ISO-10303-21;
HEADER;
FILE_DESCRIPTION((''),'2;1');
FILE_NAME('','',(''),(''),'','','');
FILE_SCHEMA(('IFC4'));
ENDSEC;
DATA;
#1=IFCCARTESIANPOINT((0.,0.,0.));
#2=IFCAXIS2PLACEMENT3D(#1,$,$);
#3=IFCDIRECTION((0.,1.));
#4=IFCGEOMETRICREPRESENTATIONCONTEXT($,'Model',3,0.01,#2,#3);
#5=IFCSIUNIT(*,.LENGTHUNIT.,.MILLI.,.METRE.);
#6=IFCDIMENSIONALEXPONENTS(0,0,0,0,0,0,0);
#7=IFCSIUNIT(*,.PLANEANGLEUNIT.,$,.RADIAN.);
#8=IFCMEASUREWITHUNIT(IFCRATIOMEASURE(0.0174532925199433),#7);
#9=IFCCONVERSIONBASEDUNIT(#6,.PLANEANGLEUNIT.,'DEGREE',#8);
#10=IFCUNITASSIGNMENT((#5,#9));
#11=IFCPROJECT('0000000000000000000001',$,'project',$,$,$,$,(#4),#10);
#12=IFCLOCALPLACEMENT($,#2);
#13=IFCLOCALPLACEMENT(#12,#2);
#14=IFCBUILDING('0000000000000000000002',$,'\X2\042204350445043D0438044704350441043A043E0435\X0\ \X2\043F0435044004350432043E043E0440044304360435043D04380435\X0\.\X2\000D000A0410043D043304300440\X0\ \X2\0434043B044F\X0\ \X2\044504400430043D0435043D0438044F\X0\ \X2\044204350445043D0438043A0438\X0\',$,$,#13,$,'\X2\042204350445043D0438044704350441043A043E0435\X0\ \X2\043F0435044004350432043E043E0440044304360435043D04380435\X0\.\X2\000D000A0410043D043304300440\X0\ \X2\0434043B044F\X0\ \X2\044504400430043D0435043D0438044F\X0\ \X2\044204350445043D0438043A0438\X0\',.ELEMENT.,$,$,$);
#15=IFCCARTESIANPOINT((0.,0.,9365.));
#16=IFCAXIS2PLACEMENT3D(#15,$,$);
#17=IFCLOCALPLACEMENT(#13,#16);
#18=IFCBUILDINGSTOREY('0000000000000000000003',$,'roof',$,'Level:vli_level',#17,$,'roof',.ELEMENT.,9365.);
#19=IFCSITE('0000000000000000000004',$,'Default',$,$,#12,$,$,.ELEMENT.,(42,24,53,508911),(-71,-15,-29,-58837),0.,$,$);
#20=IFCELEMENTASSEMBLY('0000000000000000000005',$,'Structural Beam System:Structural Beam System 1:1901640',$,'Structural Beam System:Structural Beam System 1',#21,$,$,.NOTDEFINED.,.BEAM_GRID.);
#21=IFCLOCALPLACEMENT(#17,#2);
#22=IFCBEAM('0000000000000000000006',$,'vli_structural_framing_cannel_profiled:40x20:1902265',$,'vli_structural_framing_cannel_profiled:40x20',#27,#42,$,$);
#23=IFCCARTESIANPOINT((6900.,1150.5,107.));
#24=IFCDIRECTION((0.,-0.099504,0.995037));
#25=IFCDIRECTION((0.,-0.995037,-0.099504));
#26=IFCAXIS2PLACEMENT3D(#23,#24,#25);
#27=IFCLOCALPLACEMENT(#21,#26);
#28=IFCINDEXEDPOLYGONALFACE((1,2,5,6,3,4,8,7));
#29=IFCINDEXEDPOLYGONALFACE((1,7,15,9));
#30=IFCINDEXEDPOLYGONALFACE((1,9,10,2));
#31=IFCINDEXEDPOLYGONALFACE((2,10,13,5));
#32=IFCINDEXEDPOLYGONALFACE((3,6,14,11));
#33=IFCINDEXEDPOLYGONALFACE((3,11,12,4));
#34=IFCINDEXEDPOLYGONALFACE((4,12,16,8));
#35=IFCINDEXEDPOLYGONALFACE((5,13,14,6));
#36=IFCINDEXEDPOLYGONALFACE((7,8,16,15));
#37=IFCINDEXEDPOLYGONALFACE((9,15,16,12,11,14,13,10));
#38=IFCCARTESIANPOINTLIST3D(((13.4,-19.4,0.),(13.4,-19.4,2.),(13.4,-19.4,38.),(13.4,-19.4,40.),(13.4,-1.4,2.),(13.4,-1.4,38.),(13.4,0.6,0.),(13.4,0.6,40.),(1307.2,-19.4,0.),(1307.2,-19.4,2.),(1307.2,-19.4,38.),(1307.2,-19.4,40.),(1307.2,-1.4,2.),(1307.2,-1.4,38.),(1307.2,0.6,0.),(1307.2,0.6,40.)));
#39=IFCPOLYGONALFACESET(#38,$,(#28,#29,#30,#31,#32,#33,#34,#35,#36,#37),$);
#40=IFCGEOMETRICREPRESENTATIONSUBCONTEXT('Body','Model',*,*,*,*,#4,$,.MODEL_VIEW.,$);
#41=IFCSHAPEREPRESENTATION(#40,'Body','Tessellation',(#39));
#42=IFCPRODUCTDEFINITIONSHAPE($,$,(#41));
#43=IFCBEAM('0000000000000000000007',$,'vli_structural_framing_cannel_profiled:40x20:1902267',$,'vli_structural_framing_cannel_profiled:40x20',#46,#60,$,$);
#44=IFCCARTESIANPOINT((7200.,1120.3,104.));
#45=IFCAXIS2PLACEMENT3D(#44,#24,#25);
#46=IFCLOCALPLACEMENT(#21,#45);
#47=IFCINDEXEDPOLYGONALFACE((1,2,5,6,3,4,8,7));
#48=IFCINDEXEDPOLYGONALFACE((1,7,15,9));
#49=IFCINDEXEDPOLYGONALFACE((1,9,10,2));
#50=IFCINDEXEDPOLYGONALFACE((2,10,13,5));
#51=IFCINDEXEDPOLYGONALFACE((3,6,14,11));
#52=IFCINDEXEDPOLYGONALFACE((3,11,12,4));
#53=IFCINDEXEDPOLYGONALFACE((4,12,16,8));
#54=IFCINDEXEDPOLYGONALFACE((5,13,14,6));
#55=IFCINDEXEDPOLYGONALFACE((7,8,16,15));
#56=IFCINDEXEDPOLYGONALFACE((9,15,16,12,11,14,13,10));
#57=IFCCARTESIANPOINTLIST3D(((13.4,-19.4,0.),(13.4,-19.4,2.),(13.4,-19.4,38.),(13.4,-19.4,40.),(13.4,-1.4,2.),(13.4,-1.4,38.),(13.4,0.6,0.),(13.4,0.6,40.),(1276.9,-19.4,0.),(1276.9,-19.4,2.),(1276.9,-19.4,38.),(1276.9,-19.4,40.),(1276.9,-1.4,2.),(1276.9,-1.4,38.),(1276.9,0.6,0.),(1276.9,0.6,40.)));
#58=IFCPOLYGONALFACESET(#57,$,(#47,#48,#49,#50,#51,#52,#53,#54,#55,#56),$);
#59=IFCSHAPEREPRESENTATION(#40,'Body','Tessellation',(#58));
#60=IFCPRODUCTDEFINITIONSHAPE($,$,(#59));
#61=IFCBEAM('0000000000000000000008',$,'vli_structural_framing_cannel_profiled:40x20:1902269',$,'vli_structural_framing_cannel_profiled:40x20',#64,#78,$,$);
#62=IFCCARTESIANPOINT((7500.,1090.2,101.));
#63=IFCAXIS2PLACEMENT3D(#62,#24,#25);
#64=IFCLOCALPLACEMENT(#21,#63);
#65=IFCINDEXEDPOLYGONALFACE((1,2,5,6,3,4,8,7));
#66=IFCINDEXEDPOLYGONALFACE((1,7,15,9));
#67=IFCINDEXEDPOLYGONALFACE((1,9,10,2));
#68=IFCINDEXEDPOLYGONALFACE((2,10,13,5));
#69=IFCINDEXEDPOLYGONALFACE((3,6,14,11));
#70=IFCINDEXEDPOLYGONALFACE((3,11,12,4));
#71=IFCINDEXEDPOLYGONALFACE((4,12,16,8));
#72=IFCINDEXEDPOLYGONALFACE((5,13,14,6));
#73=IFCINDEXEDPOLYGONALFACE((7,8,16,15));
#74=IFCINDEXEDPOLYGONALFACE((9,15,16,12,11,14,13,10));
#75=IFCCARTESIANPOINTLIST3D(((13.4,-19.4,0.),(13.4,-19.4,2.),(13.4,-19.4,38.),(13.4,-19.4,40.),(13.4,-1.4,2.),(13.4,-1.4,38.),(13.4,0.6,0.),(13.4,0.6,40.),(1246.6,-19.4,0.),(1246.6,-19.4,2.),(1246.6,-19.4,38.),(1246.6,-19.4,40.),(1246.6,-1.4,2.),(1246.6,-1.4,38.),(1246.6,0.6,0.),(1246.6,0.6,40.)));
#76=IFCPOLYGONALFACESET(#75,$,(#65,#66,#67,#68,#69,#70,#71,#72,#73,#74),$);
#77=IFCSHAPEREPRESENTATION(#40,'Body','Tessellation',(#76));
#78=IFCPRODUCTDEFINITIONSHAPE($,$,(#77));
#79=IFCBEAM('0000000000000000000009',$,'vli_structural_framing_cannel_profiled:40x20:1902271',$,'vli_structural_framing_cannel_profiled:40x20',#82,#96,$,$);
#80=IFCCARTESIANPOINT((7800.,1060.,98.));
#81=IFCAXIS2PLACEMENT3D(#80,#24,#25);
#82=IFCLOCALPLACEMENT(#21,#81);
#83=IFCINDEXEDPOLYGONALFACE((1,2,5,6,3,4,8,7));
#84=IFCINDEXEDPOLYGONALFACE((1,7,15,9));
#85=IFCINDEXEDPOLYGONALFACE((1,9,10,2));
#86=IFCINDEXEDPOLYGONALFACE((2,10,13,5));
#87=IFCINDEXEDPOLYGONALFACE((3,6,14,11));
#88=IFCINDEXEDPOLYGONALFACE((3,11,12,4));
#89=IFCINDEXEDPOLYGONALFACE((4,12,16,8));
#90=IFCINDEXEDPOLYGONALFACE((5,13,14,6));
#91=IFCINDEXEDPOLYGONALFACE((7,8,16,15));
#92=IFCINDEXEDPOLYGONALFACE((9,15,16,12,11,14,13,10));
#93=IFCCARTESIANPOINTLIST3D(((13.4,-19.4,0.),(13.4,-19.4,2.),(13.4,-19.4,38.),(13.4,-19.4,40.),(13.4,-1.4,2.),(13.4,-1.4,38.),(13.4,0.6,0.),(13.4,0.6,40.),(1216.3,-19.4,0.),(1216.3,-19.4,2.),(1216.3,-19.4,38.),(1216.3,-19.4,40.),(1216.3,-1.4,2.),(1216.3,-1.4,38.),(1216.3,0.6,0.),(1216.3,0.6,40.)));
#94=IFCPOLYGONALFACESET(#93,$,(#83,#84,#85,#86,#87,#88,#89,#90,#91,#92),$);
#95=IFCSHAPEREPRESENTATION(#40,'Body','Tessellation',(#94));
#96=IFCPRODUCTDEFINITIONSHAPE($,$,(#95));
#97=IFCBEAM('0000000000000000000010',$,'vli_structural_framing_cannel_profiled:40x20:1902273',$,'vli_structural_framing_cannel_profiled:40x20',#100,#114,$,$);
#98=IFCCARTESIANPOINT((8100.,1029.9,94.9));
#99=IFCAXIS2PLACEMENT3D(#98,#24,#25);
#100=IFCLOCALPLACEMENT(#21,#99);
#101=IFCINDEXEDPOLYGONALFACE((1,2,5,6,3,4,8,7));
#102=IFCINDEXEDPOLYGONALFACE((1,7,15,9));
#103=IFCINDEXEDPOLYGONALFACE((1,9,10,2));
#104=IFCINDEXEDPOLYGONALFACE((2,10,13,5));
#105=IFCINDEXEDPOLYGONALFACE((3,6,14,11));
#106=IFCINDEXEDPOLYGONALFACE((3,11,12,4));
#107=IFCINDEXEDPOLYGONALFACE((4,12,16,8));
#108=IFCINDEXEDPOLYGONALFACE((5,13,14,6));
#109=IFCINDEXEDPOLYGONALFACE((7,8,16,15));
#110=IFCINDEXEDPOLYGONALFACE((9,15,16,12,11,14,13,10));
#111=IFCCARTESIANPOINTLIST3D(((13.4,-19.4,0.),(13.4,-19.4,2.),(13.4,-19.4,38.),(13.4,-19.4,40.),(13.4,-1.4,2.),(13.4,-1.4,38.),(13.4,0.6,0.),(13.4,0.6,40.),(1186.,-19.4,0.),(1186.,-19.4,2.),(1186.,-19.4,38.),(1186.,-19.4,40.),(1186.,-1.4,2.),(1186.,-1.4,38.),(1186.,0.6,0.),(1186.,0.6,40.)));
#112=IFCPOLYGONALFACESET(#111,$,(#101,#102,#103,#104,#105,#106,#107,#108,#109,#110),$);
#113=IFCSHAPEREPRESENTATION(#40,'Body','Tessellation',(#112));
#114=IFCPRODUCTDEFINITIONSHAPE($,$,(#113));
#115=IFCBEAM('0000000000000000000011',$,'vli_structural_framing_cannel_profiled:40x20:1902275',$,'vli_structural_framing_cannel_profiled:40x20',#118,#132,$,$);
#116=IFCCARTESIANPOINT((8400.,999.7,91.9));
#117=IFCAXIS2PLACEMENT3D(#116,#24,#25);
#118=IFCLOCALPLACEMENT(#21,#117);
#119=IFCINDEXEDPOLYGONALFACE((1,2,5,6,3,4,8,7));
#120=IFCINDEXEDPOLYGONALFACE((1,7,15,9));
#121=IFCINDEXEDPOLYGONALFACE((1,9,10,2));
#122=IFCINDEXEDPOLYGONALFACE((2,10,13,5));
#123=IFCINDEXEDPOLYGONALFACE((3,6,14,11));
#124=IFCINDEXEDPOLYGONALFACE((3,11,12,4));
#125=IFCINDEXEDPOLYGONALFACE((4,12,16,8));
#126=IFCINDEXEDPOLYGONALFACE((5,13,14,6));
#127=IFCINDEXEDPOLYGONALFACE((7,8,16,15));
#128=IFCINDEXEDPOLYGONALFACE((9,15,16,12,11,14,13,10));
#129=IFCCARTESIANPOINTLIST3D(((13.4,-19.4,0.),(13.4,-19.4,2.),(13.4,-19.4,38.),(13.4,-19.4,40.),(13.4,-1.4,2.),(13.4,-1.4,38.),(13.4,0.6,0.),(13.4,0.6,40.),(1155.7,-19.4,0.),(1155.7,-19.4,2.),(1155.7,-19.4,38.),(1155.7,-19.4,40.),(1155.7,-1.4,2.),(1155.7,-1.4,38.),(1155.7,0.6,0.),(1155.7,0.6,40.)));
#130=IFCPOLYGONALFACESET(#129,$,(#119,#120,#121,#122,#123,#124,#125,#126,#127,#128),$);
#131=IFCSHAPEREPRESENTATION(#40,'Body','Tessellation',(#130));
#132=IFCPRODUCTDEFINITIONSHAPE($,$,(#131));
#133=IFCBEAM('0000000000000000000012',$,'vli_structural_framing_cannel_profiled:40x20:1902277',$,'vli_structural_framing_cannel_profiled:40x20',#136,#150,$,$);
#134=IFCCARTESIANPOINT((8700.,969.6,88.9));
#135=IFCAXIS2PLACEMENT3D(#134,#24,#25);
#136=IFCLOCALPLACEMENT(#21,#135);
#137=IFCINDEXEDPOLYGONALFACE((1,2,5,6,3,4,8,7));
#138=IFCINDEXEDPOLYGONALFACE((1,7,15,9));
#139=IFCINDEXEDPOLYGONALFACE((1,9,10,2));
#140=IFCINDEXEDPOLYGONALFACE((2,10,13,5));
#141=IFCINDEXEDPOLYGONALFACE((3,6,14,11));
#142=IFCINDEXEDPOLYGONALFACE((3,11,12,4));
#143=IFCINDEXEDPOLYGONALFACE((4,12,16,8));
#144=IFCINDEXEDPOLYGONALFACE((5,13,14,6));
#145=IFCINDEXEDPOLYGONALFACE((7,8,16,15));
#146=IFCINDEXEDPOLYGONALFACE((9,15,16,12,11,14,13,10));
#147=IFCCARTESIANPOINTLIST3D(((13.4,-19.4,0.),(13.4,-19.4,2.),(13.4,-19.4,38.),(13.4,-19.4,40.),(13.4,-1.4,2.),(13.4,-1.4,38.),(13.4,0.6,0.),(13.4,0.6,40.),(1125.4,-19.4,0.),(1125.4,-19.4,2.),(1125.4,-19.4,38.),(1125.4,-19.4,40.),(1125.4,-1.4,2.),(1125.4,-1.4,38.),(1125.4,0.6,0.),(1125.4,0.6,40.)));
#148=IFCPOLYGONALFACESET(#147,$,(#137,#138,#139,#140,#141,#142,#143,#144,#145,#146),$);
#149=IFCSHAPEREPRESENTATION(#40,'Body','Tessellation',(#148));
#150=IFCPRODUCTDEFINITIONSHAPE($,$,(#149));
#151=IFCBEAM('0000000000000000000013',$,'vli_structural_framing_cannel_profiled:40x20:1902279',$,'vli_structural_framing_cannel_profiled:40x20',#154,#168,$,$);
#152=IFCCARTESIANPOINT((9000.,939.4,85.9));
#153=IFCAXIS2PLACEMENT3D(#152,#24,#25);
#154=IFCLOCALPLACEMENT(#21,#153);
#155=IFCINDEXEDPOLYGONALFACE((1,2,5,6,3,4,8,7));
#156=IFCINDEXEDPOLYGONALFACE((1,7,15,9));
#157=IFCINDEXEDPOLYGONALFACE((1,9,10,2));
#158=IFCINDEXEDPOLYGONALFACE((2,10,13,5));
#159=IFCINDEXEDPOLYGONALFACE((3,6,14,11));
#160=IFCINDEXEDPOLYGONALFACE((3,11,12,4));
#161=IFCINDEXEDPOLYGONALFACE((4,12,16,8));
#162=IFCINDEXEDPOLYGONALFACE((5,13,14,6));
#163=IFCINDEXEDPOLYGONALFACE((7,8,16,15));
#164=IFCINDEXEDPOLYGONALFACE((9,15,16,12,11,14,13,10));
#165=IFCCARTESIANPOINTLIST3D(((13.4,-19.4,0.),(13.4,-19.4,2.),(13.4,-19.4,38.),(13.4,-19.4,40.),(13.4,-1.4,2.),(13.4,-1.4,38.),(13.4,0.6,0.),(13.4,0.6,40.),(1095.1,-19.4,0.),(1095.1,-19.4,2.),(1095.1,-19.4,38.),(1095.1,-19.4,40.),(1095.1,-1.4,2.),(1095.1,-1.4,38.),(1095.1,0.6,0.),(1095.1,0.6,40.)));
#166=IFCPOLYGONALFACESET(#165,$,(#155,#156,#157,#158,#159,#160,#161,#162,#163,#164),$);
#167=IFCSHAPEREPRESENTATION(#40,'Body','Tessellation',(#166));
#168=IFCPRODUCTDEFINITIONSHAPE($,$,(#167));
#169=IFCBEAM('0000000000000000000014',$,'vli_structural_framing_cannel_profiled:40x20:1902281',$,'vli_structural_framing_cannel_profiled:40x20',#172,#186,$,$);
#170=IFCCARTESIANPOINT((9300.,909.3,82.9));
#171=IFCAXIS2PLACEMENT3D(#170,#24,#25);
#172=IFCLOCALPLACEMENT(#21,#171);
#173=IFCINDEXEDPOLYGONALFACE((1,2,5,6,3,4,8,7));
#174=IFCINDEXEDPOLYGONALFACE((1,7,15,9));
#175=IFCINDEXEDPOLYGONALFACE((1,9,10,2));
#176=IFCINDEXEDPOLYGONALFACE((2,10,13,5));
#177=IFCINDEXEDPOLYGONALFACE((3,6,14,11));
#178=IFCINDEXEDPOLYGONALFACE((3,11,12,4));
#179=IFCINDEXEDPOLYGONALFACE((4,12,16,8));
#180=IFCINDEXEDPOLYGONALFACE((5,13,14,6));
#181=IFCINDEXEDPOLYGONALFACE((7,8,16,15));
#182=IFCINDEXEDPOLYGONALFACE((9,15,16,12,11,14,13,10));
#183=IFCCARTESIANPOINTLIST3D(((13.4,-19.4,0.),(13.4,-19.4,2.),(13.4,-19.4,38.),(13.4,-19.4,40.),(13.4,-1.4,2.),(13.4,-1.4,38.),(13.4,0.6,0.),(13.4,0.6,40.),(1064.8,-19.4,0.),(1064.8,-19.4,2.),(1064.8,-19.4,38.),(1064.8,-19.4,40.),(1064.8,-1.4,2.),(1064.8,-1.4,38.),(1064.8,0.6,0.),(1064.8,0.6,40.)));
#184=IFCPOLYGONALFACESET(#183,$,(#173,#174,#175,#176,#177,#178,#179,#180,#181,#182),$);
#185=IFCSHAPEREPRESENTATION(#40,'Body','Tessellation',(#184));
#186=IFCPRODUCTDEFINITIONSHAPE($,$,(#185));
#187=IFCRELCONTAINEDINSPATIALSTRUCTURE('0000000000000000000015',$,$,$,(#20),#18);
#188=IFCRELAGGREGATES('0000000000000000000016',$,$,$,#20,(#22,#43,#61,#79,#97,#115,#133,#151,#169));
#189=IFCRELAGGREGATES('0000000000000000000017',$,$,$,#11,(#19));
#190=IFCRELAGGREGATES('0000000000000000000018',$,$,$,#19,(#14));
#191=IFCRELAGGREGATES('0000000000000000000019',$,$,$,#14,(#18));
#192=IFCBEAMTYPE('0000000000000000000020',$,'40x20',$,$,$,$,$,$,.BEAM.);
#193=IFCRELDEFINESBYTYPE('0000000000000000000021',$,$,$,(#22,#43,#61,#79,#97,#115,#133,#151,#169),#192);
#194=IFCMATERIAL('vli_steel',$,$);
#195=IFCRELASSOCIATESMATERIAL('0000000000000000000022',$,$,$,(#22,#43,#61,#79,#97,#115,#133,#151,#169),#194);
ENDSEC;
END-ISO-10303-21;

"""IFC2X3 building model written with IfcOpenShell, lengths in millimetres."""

from ifc_helpers import new_model, entity, si_unit, converted_unit, direction, frame, origin, place, context, subcontext, project, spatial, polyline, outline, extrude, material, type_object, element, aggregate, save


model = new_model("IFC2X3")

# Units and contexts
model_context = context("Model", 3, precision=0.01, world=origin(), true_north=direction((0.0, 1.0)))
body_context = subcontext(model_context, "Body", "Model", "MODEL_VIEW")
ifc_project = project(units=[si_unit("LENGTHUNIT", "METRE", prefix="MILLI"), converted_unit("PLANEANGLEUNIT", "DEGREE", entity("IfcRatioMeasure", 0.0174532925199433), si_unit("PLANEANGLEUNIT", "RADIAN"), dimensions=[0, 0, 0, 0, 0, 0, 0])], contexts=[model_context])

# Site, building, storey
site_placement = place(None, origin())
site = spatial("IfcSite", under=ifc_project, at=site_placement, Name="Default", CompositionType="ELEMENT", RefLatitude=(42, 24, 53, 508911), RefLongitude=(-71, -15, -29, -58837), RefElevation=0.0)
building_placement = place(site_placement, origin())
building = spatial("IfcBuilding", under=site, at=building_placement, Name="Техническое перевооружение.\r\nАнгар для хранения техники", LongName="Техническое перевооружение.\r\nАнгар для хранения техники", CompositionType="ELEMENT")
storey_placement = place(building_placement, frame((0.0, 0.0, 9365.0)))
storey = spatial("IfcBuildingStorey", under=building, at=storey_placement, Name="roof", ObjectType="Level:vli_level", LongName="roof", CompositionType="ELEMENT", Elevation=9365.0)

# Element assembly, beams
assembly_1_placement = place(storey_placement, origin())
assembly_1 = element("IfcElementAssembly", 1, at=assembly_1_placement, inside=storey, Name="Structural Beam System:Structural Beam System 1:1901640", ObjectType="Structural Beam System:Structural Beam System 1", AssemblyPlace="NOTDEFINED", PredefinedType="BEAM_GRID")
ifc_material = material(Name="vli_steel")
beam_type = type_object("IfcBeamType", Name="40x20", PredefinedType="BEAM")
beam_1_placement = place(assembly_1_placement, frame((6900.0, 1150.5, 107.0), z_axis=(0.0, -0.099504, 0.995037), x_axis=(0.0, -0.995037, -0.099504)))
beam_1 = element("IfcBeam", 2, at=beam_1_placement, type_object=beam_type, material=ifc_material, Name="vli_structural_framing_cannel_profiled:40x20:1902265", ObjectType="vli_structural_framing_cannel_profiled:40x20", context=body_context, shape_type="SweptSolid", body=[
    extrude(outline(polyline([(-20.0, -9.5), (-18.0, -9.5), (-18.0, 8.5), (18.0, 8.5), (18.0, -9.5), (20.0, -9.5), (20.0, 10.5), (-20.0, 10.5), (-20.0, -9.5)])), frame((13.4, -9.9, 20.0), z_axis=(1.0, 0.0, 0.0), x_axis=(0.0, 0.0, -1.0)), (0.0, 0.0, 1.0), 1293.9),
])
beam_2_placement = place(assembly_1_placement, frame((7200.0, 1120.3, 104.0), z_axis=(0.0, -0.099504, 0.995037), x_axis=(0.0, -0.995037, -0.099504)))
beam_2 = element("IfcBeam", 3, at=beam_2_placement, type_object=beam_type, material=ifc_material, Name="vli_structural_framing_cannel_profiled:40x20:1902267", ObjectType="vli_structural_framing_cannel_profiled:40x20", context=body_context, shape_type="SweptSolid", body=[
    extrude(outline(polyline([(-20.0, -9.5), (-18.0, -9.5), (-18.0, 8.5), (18.0, 8.5), (18.0, -9.5), (20.0, -9.5), (20.0, 10.5), (-20.0, 10.5), (-20.0, -9.5)])), frame((13.4, -9.9, 20.0), z_axis=(1.0, 0.0, 0.0), x_axis=(0.0, 0.0, -1.0)), (0.0, 0.0, 1.0), 1263.6),
])
beam_3_placement = place(assembly_1_placement, frame((7500.0, 1090.2, 101.0), z_axis=(0.0, -0.099504, 0.995037), x_axis=(0.0, -0.995037, -0.099504)))
beam_3 = element("IfcBeam", 4, at=beam_3_placement, type_object=beam_type, material=ifc_material, Name="vli_structural_framing_cannel_profiled:40x20:1902269", ObjectType="vli_structural_framing_cannel_profiled:40x20", context=body_context, shape_type="SweptSolid", body=[
    extrude(outline(polyline([(-20.0, -9.5), (-18.0, -9.5), (-18.0, 8.5), (18.0, 8.5), (18.0, -9.5), (20.0, -9.5), (20.0, 10.5), (-20.0, 10.5), (-20.0, -9.5)])), frame((13.4, -9.9, 20.0), z_axis=(1.0, 0.0, 0.0), x_axis=(0.0, 0.0, -1.0)), (0.0, 0.0, 1.0), 1233.3),
])
beam_4_placement = place(assembly_1_placement, frame((7800.0, 1060.0, 98.0), z_axis=(0.0, -0.099504, 0.995037), x_axis=(0.0, -0.995037, -0.099504)))
beam_4 = element("IfcBeam", 5, at=beam_4_placement, type_object=beam_type, material=ifc_material, Name="vli_structural_framing_cannel_profiled:40x20:1902271", ObjectType="vli_structural_framing_cannel_profiled:40x20", context=body_context, shape_type="SweptSolid", body=[
    extrude(outline(polyline([(-20.0, -9.5), (-18.0, -9.5), (-18.0, 8.5), (18.0, 8.5), (18.0, -9.5), (20.0, -9.5), (20.0, 10.5), (-20.0, 10.5), (-20.0, -9.5)])), frame((13.4, -9.9, 20.0), z_axis=(1.0, 0.0, 0.0), x_axis=(0.0, 0.0, -1.0)), (0.0, 0.0, 1.0), 1203.0),
])
beam_5_placement = place(assembly_1_placement, frame((8100.0, 1029.9, 94.9), z_axis=(0.0, -0.099504, 0.995037), x_axis=(0.0, -0.995037, -0.099504)))
beam_5 = element("IfcBeam", 6, at=beam_5_placement, type_object=beam_type, material=ifc_material, Name="vli_structural_framing_cannel_profiled:40x20:1902273", ObjectType="vli_structural_framing_cannel_profiled:40x20", context=body_context, shape_type="SweptSolid", body=[
    extrude(outline(polyline([(-20.0, -9.5), (-18.0, -9.5), (-18.0, 8.5), (18.0, 8.5), (18.0, -9.5), (20.0, -9.5), (20.0, 10.5), (-20.0, 10.5), (-20.0, -9.5)])), frame((13.4, -9.9, 20.0), z_axis=(1.0, 0.0, 0.0), x_axis=(0.0, 0.0, -1.0)), (0.0, 0.0, 1.0), 1172.7),
])
beam_6_placement = place(assembly_1_placement, frame((8400.0, 999.7, 91.9), z_axis=(0.0, -0.099504, 0.995037), x_axis=(0.0, -0.995037, -0.099504)))
beam_6 = element("IfcBeam", 7, at=beam_6_placement, type_object=beam_type, material=ifc_material, Name="vli_structural_framing_cannel_profiled:40x20:1902275", ObjectType="vli_structural_framing_cannel_profiled:40x20", context=body_context, shape_type="SweptSolid", body=[
    extrude(outline(polyline([(-20.0, -9.5), (-18.0, -9.5), (-18.0, 8.5), (18.0, 8.5), (18.0, -9.5), (20.0, -9.5), (20.0, 10.5), (-20.0, 10.5), (-20.0, -9.5)])), frame((13.4, -9.9, 20.0), z_axis=(1.0, 0.0, 0.0), x_axis=(0.0, 0.0, -1.0)), (0.0, 0.0, 1.0), 1142.4),
])
beam_7_placement = place(assembly_1_placement, frame((8700.0, 969.6, 88.9), z_axis=(0.0, -0.099504, 0.995037), x_axis=(0.0, -0.995037, -0.099504)))
beam_7 = element("IfcBeam", 8, at=beam_7_placement, type_object=beam_type, material=ifc_material, Name="vli_structural_framing_cannel_profiled:40x20:1902277", ObjectType="vli_structural_framing_cannel_profiled:40x20", context=body_context, shape_type="SweptSolid", body=[
    extrude(outline(polyline([(-20.0, -9.5), (-18.0, -9.5), (-18.0, 8.5), (18.0, 8.5), (18.0, -9.5), (20.0, -9.5), (20.0, 10.5), (-20.0, 10.5), (-20.0, -9.5)])), frame((13.4, -9.9, 20.0), z_axis=(1.0, 0.0, 0.0), x_axis=(0.0, 0.0, -1.0)), (0.0, 0.0, 1.0), 1112.1),
])
beam_8_placement = place(assembly_1_placement, frame((9000.0, 939.4, 85.9), z_axis=(0.0, -0.099504, 0.995037), x_axis=(0.0, -0.995037, -0.099504)))
beam_8 = element("IfcBeam", 9, at=beam_8_placement, type_object=beam_type, material=ifc_material, Name="vli_structural_framing_cannel_profiled:40x20:1902279", ObjectType="vli_structural_framing_cannel_profiled:40x20", context=body_context, shape_type="SweptSolid", body=[
    extrude(outline(polyline([(-20.0, -9.5), (-18.0, -9.5), (-18.0, 8.5), (18.0, 8.5), (18.0, -9.5), (20.0, -9.5), (20.0, 10.5), (-20.0, 10.5), (-20.0, -9.5)])), frame((13.4, -9.9, 20.0), z_axis=(1.0, 0.0, 0.0), x_axis=(0.0, 0.0, -1.0)), (0.0, 0.0, 1.0), 1081.8),
])
beam_9_placement = place(assembly_1_placement, frame((9300.0, 909.3, 82.9), z_axis=(0.0, -0.099504, 0.995037), x_axis=(0.0, -0.995037, -0.099504)))
beam_9 = element("IfcBeam", 10, at=beam_9_placement, type_object=beam_type, material=ifc_material, Name="vli_structural_framing_cannel_profiled:40x20:1902281", ObjectType="vli_structural_framing_cannel_profiled:40x20", context=body_context, shape_type="SweptSolid", body=[
    extrude(outline(polyline([(-20.0, -9.5), (-18.0, -9.5), (-18.0, 8.5), (18.0, 8.5), (18.0, -9.5), (20.0, -9.5), (20.0, 10.5), (-20.0, 10.5), (-20.0, -9.5)])), frame((13.4, -9.9, 20.0), z_axis=(1.0, 0.0, 0.0), x_axis=(0.0, 0.0, -1.0)), (0.0, 0.0, 1.0), 1051.5),
])
aggregate(assembly_1, [beam_1, beam_2, beam_3, beam_4, beam_5, beam_6, beam_7, beam_8, beam_9])

save(model, "model.ifc")
